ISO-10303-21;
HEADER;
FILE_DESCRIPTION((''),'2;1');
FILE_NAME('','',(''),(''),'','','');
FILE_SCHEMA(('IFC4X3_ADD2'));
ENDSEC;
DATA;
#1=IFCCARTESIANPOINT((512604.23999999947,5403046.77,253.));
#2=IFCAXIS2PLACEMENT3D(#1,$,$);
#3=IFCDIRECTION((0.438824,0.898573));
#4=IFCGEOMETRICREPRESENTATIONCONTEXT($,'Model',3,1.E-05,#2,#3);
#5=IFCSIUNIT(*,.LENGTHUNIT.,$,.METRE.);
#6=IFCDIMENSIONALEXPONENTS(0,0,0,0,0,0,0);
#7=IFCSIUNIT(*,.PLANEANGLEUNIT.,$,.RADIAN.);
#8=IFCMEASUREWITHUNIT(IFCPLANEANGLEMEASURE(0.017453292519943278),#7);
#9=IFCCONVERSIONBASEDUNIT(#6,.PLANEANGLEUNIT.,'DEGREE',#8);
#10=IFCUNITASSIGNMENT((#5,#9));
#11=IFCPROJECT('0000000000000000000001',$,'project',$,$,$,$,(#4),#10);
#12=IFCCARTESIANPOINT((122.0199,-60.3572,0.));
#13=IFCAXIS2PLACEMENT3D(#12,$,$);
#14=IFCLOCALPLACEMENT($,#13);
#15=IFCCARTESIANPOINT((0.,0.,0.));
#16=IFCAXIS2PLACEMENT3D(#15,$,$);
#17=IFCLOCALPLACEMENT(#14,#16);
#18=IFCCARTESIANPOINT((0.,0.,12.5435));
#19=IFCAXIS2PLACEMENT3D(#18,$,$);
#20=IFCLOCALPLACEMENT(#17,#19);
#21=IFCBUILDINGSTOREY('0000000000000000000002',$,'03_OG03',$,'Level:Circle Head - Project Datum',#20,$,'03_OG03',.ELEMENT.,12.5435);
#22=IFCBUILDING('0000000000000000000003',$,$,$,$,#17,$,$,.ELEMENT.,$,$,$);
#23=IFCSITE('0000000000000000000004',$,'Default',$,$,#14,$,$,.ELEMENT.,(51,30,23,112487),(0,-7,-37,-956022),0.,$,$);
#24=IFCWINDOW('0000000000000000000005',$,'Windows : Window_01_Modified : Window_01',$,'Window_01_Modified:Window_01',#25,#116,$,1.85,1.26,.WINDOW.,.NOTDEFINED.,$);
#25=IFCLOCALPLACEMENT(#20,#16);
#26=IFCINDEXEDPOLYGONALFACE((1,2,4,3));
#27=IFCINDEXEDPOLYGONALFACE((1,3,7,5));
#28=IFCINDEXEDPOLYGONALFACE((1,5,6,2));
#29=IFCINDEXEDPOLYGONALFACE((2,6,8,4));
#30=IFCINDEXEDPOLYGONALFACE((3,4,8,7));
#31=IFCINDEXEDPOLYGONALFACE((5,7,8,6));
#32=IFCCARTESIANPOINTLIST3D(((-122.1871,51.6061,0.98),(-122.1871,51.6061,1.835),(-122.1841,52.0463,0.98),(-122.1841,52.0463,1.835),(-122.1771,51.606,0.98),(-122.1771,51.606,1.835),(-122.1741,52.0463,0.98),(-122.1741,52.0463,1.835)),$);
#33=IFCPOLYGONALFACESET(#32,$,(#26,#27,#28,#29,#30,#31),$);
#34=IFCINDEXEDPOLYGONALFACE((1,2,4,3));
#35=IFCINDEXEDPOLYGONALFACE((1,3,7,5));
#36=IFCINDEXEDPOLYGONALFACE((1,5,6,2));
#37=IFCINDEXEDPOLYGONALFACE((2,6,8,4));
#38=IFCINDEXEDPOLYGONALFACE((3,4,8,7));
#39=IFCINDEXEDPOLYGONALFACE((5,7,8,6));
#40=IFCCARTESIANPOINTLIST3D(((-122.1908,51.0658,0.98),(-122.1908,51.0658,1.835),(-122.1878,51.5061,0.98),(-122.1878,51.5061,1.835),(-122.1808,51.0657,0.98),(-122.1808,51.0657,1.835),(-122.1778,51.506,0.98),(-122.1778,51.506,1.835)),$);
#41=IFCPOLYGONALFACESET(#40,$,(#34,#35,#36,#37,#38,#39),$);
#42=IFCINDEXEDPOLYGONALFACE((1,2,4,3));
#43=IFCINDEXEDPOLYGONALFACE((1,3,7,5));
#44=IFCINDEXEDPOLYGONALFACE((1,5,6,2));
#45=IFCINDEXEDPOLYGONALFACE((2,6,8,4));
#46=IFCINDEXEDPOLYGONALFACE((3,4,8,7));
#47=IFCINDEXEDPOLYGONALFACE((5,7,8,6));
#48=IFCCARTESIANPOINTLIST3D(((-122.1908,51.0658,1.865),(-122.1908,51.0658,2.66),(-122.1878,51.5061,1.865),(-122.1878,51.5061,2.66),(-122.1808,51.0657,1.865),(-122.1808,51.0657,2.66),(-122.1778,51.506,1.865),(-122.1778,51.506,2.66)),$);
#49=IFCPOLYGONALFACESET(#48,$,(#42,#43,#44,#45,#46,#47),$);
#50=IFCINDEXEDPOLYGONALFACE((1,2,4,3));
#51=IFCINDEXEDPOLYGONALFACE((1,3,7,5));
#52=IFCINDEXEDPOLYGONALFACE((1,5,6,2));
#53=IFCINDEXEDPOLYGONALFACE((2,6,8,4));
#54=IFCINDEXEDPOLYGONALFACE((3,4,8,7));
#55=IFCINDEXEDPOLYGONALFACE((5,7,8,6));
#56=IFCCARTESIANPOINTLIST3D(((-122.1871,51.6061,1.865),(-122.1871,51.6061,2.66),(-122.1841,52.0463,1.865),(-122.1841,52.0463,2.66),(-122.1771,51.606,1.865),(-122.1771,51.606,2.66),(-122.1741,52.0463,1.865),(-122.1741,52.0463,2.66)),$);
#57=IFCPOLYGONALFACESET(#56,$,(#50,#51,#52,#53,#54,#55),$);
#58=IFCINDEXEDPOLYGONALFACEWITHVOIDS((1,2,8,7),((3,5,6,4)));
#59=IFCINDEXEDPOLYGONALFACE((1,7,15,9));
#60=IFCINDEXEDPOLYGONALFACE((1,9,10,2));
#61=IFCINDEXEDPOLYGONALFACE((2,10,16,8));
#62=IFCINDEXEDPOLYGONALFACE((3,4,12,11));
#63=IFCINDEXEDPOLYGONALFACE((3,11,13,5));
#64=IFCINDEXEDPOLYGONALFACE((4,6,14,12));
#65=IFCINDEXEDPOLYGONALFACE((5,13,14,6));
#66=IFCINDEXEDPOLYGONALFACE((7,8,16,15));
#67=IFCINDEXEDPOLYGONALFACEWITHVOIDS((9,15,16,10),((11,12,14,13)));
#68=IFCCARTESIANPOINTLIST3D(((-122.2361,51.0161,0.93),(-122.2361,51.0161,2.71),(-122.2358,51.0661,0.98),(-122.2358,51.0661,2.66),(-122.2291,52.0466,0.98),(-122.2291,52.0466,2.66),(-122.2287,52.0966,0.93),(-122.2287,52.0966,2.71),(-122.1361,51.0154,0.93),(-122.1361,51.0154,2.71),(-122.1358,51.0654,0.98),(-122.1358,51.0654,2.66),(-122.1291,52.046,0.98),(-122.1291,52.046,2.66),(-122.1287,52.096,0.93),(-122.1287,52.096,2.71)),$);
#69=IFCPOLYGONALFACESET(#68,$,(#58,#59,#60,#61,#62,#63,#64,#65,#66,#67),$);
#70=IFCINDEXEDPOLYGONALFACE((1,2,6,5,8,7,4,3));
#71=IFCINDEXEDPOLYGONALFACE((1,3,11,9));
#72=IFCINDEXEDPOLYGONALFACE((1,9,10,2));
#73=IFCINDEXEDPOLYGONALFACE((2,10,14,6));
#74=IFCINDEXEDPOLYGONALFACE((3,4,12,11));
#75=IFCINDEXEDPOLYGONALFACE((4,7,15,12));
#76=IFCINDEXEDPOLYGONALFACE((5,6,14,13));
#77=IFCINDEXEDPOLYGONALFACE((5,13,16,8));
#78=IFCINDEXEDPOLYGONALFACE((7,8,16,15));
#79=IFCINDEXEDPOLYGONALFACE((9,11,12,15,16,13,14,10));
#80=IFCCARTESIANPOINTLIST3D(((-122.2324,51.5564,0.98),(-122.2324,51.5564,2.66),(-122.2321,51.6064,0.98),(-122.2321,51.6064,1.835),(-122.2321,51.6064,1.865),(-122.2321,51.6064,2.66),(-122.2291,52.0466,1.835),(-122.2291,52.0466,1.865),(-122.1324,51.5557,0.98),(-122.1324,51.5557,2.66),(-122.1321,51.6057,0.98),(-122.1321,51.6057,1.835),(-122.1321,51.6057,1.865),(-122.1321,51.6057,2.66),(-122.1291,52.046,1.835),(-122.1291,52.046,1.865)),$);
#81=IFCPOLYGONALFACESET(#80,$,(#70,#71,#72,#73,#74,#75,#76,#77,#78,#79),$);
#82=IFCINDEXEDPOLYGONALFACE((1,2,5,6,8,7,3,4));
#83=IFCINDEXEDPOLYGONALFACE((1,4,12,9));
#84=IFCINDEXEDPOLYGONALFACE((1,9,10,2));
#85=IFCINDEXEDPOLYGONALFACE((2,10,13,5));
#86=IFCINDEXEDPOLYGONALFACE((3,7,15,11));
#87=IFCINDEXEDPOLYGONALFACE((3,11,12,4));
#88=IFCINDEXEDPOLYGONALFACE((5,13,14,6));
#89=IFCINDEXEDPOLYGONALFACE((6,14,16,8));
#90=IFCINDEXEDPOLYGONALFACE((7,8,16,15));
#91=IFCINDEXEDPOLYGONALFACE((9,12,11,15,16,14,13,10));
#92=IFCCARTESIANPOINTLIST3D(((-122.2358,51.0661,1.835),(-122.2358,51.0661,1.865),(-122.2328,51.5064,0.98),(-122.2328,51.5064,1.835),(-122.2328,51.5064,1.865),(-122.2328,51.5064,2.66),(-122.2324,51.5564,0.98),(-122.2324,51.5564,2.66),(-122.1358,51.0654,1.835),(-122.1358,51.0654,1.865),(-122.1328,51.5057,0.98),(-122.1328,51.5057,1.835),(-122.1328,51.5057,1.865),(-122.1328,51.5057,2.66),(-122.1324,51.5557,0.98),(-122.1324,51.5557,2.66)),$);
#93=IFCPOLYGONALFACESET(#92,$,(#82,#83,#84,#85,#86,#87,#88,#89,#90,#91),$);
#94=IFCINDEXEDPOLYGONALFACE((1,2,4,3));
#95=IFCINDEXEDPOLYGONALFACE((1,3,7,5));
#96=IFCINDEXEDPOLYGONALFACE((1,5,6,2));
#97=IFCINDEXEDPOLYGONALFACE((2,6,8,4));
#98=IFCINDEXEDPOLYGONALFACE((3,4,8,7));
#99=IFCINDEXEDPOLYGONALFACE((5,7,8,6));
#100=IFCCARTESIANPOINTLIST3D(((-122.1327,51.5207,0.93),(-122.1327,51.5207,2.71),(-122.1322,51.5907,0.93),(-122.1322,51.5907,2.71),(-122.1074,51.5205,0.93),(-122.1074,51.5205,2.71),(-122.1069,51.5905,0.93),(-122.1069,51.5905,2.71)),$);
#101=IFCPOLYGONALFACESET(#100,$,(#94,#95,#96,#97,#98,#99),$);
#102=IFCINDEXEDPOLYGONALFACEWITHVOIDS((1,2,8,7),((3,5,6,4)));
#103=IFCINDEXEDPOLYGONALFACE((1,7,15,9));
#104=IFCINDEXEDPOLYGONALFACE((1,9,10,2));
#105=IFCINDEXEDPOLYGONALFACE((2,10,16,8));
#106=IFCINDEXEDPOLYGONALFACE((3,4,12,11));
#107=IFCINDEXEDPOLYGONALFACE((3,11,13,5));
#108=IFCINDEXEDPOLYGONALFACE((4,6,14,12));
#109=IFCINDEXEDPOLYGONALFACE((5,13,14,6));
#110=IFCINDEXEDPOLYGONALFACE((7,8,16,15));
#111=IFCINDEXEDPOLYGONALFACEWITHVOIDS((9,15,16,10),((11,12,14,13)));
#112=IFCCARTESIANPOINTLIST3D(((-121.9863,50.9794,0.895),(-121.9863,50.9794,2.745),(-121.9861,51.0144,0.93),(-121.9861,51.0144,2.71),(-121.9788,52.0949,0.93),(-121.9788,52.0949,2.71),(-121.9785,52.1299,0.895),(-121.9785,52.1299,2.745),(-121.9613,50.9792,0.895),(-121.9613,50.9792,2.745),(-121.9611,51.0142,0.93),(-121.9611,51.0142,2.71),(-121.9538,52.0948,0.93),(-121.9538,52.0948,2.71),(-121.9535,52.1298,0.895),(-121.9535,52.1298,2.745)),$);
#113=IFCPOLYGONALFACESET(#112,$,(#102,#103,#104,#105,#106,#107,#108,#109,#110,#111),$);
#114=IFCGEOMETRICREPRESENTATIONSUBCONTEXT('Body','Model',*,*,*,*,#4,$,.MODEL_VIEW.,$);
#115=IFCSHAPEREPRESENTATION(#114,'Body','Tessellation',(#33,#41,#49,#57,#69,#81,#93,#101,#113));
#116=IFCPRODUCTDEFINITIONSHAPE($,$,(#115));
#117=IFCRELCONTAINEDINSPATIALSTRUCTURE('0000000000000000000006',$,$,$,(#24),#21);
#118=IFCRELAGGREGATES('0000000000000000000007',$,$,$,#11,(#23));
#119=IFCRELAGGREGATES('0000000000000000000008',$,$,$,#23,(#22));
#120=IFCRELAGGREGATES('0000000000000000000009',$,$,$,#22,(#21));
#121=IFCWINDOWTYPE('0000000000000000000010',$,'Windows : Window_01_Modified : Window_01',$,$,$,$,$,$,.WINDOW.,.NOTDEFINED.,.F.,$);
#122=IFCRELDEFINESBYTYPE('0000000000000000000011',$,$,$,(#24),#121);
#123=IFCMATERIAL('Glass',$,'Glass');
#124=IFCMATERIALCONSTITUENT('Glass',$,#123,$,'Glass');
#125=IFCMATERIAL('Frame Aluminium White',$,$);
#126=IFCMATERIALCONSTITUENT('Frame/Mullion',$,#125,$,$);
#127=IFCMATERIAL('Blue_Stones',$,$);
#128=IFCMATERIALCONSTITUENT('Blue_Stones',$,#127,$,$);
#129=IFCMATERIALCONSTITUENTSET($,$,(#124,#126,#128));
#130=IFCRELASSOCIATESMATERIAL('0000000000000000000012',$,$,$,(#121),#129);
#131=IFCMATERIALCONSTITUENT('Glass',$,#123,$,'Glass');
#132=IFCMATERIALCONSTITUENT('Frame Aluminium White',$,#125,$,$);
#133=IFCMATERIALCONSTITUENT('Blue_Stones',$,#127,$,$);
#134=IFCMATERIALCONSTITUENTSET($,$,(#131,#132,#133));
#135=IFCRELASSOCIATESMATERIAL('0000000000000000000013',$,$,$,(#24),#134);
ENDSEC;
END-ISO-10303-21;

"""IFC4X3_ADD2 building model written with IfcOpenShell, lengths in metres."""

from ifc_helpers import new_model, entity, si_unit, converted_unit, direction, frame, frame_2d, origin, place, context, subcontext, project, spatial, polyline, rectangle, outline, extrude, source, transform, mapped, material, constituent, constituent_set, type_object, type_shapes, element, save


model = new_model("IFC4X3_ADD2")

# Units and contexts
model_context = context("Model", 3, precision=1e-05, world=frame((512604.23999999947, 5403046.77, 253.0)), true_north=direction((0.438824, 0.898573)))
body_context = subcontext(model_context, "Body", "Model", "MODEL_VIEW")
ifc_project = project(units=[si_unit("LENGTHUNIT", "METRE"), converted_unit("PLANEANGLEUNIT", "DEGREE", entity("IfcPlaneAngleMeasure", 0.017453292519943278), si_unit("PLANEANGLEUNIT", "RADIAN"), dimensions=[0, 0, 0, 0, 0, 0, 0])], contexts=[model_context])

# Site, building, storey
site_placement = place(None, frame((122.0199, -60.3572, 0.0)))
site = spatial("IfcSite", under=ifc_project, at=site_placement, Name="Default", CompositionType="ELEMENT", RefLatitude=(51, 30, 23, 112487), RefLongitude=(0, -7, -37, -956022), RefElevation=0.0)
building_placement = place(site_placement, origin())
building = spatial("IfcBuilding", under=site, at=building_placement, CompositionType="ELEMENT")
storey_placement = place(building_placement, frame((0.0, 0.0, 12.5435)))
storey = spatial("IfcBuildingStorey", under=building, at=storey_placement, Name="03_OG03", ObjectType="Level:Circle Head - Project Datum", LongName="03_OG03", CompositionType="ELEMENT", Elevation=12.5435)

# Window
ifc_material_1 = material(Name="Glass", Category="Glass")
ifc_material_2 = material(Name="Frame Aluminium White")
ifc_material_3 = material(Name="Blue_Stones")
ifc_constituent_1 = constituent(ifc_material_1, Name="Glass", Category="Glass")
ifc_constituent_2 = constituent(ifc_material_2, Name="Frame Aluminium White")
ifc_constituent_3 = constituent(ifc_material_3, Name="Blue_Stones")
ifc_constituent_set_1 = constituent_set(constituents=[ifc_constituent_1, ifc_constituent_2, ifc_constituent_3])
ifc_constituent_4 = constituent(ifc_material_1, Name="Glass", Category="Glass")
ifc_constituent_5 = constituent(ifc_material_2, Name="Frame/Mullion")
ifc_constituent_6 = constituent(ifc_material_3, Name="Blue_Stones")
ifc_constituent_set_2 = constituent_set(constituents=[ifc_constituent_4, ifc_constituent_5, ifc_constituent_6])
window_type_1 = type_object("IfcWindowType", Name="Windows : Window_01_Modified : Window_01", ParameterTakesPrecedence=False, PartitioningType="NOTDEFINED", PredefinedType="WINDOW", material=ifc_constituent_set_2)
shared_shape_1 = source(origin(), body_context, "Body", "SweptSolid", [
    extrude(rectangle(XDim=0.4403, YDim=0.01, at=frame_2d((0.0, 0.0), x_axis=(1.0, 0.0))), frame((0.3086, -0.2, 0.0514), z_axis=(0.0, 0.0, 1.0), x_axis=(-1.0, 0.0, 0.0)), (0.0, 0.0, 1.0), 0.855),
    extrude(rectangle(XDim=0.01, YDim=0.4403, at=frame_2d((0.0, 0.0), x_axis=(1.0, 0.0))), frame((0.8489, -0.2, 0.0514), z_axis=(0.0, 0.0, 1.0), x_axis=(0.0, 1.0, 0.0)), (0.0, 0.0, 1.0), 0.855),
    extrude(rectangle(XDim=0.4403, YDim=0.01, at=frame_2d((0.0, 0.0), x_axis=(1.0, 0.0))), frame((0.8489, -0.2, 0.9364), z_axis=(0.0, 0.0, 1.0), x_axis=(-1.0, 0.0, 0.0)), (0.0, 0.0, 1.0), 0.795),
    extrude(rectangle(XDim=0.4403, YDim=0.01, at=frame_2d((0.0, 0.0), x_axis=(1.0, 0.0))), frame((0.3086, -0.2, 0.9364), z_axis=(0.0, 0.0, 1.0), x_axis=(-1.0, 0.0, 0.0)), (0.0, 0.0, 1.0), 0.795),
    extrude(outline(polyline([(-0.89, -0.5403), (0.89, -0.5403), (0.89, 0.5403), (-0.89, 0.5403), (-0.89, -0.5403)]), holes=[polyline([(0.84, 0.4903), (0.84, -0.4903), (-0.84, -0.4903), (-0.84, 0.4903), (0.84, 0.4903)])]), frame((0.5787, -0.25, 0.8914), z_axis=(0.0, 1.0, 0.0), x_axis=(0.0, 0.0, 1.0)), (0.0, 0.0, 1.0), 0.1),
    extrude(outline(polyline([(0.03, 0.0976), (0.825, 0.0976), (0.825, 0.1476), (-0.855, 0.1476), (-0.855, 0.0976), (0.0, 0.0976), (0.0, -0.3427), (0.03, -0.3427), (0.03, 0.0976)])), frame((0.4312, -0.25, 0.9064), z_axis=(0.0, 1.0, 0.0), x_axis=(0.0, 0.0, 1.0)), (0.0, 0.0, 1.0), 0.1),
    extrude(outline(polyline([(-0.825, -0.0976), (-0.825, -0.1476), (0.855, -0.1476), (0.855, -0.0976), (0.0, -0.0976), (0.0, 0.3427), (-0.03, 0.3427), (-0.03, -0.0976), (-0.825, -0.0976)])), frame((0.7263, -0.25, 0.9064), z_axis=(0.0, -1.0, 0.0), x_axis=(0.0, 0.0, -1.0)), (0.0, 0.0, -1.0), 0.1),
    extrude(rectangle(XDim=0.0253, YDim=0.07, at=frame_2d((0.0, 0.0), x_axis=(1.0, 0.0))), frame((0.5787, -0.1374, 0.0014), z_axis=(0.0, 0.0, 1.0), x_axis=(0.0, -1.0, 0.0)), (0.0, 0.0, 1.0), 1.78),
    extrude(outline(polyline([(-0.5753, -0.925), (0.5753, -0.925), (0.5753, 0.925), (-0.5753, 0.925), (-0.5753, -0.925)]), holes=[polyline([(-0.5403, -0.89), (-0.5403, 0.89), (0.5403, 0.89), (0.5403, -0.89), (-0.5403, -0.89)])]), frame((0.5787, 0.0, 0.8914), z_axis=(0.0, 1.0, 0.0), x_axis=(1.0, 0.0, 0.0)), (0.0, 0.0, 1.0), 0.025),
])
type_shapes(window_type_1, [shared_shape_1])
window_1_placement = place(storey_placement, frame((-121.9785, 52.1334, 0.9286), z_axis=(0.0, 0.0, 1.0), x_axis=(-0.0068, -0.999977, 0.0)))
element("IfcWindow", 1, at=window_1_placement, inside=storey, type_object=window_type_1, material=ifc_constituent_set_1, Name="Windows : Window_01_Modified : Window_01", ObjectType="Window_01_Modified:Window_01", OverallHeight=1.85, OverallWidth=1.26, PartitioningType="NOTDEFINED", PredefinedType="WINDOW", context=body_context, shape_type="MappedRepresentation", body=[
    mapped(shared_shape_1, transform((0.0, 0.0, 0.0), scale=1.0)),
])

save(model, "model.ifc")
